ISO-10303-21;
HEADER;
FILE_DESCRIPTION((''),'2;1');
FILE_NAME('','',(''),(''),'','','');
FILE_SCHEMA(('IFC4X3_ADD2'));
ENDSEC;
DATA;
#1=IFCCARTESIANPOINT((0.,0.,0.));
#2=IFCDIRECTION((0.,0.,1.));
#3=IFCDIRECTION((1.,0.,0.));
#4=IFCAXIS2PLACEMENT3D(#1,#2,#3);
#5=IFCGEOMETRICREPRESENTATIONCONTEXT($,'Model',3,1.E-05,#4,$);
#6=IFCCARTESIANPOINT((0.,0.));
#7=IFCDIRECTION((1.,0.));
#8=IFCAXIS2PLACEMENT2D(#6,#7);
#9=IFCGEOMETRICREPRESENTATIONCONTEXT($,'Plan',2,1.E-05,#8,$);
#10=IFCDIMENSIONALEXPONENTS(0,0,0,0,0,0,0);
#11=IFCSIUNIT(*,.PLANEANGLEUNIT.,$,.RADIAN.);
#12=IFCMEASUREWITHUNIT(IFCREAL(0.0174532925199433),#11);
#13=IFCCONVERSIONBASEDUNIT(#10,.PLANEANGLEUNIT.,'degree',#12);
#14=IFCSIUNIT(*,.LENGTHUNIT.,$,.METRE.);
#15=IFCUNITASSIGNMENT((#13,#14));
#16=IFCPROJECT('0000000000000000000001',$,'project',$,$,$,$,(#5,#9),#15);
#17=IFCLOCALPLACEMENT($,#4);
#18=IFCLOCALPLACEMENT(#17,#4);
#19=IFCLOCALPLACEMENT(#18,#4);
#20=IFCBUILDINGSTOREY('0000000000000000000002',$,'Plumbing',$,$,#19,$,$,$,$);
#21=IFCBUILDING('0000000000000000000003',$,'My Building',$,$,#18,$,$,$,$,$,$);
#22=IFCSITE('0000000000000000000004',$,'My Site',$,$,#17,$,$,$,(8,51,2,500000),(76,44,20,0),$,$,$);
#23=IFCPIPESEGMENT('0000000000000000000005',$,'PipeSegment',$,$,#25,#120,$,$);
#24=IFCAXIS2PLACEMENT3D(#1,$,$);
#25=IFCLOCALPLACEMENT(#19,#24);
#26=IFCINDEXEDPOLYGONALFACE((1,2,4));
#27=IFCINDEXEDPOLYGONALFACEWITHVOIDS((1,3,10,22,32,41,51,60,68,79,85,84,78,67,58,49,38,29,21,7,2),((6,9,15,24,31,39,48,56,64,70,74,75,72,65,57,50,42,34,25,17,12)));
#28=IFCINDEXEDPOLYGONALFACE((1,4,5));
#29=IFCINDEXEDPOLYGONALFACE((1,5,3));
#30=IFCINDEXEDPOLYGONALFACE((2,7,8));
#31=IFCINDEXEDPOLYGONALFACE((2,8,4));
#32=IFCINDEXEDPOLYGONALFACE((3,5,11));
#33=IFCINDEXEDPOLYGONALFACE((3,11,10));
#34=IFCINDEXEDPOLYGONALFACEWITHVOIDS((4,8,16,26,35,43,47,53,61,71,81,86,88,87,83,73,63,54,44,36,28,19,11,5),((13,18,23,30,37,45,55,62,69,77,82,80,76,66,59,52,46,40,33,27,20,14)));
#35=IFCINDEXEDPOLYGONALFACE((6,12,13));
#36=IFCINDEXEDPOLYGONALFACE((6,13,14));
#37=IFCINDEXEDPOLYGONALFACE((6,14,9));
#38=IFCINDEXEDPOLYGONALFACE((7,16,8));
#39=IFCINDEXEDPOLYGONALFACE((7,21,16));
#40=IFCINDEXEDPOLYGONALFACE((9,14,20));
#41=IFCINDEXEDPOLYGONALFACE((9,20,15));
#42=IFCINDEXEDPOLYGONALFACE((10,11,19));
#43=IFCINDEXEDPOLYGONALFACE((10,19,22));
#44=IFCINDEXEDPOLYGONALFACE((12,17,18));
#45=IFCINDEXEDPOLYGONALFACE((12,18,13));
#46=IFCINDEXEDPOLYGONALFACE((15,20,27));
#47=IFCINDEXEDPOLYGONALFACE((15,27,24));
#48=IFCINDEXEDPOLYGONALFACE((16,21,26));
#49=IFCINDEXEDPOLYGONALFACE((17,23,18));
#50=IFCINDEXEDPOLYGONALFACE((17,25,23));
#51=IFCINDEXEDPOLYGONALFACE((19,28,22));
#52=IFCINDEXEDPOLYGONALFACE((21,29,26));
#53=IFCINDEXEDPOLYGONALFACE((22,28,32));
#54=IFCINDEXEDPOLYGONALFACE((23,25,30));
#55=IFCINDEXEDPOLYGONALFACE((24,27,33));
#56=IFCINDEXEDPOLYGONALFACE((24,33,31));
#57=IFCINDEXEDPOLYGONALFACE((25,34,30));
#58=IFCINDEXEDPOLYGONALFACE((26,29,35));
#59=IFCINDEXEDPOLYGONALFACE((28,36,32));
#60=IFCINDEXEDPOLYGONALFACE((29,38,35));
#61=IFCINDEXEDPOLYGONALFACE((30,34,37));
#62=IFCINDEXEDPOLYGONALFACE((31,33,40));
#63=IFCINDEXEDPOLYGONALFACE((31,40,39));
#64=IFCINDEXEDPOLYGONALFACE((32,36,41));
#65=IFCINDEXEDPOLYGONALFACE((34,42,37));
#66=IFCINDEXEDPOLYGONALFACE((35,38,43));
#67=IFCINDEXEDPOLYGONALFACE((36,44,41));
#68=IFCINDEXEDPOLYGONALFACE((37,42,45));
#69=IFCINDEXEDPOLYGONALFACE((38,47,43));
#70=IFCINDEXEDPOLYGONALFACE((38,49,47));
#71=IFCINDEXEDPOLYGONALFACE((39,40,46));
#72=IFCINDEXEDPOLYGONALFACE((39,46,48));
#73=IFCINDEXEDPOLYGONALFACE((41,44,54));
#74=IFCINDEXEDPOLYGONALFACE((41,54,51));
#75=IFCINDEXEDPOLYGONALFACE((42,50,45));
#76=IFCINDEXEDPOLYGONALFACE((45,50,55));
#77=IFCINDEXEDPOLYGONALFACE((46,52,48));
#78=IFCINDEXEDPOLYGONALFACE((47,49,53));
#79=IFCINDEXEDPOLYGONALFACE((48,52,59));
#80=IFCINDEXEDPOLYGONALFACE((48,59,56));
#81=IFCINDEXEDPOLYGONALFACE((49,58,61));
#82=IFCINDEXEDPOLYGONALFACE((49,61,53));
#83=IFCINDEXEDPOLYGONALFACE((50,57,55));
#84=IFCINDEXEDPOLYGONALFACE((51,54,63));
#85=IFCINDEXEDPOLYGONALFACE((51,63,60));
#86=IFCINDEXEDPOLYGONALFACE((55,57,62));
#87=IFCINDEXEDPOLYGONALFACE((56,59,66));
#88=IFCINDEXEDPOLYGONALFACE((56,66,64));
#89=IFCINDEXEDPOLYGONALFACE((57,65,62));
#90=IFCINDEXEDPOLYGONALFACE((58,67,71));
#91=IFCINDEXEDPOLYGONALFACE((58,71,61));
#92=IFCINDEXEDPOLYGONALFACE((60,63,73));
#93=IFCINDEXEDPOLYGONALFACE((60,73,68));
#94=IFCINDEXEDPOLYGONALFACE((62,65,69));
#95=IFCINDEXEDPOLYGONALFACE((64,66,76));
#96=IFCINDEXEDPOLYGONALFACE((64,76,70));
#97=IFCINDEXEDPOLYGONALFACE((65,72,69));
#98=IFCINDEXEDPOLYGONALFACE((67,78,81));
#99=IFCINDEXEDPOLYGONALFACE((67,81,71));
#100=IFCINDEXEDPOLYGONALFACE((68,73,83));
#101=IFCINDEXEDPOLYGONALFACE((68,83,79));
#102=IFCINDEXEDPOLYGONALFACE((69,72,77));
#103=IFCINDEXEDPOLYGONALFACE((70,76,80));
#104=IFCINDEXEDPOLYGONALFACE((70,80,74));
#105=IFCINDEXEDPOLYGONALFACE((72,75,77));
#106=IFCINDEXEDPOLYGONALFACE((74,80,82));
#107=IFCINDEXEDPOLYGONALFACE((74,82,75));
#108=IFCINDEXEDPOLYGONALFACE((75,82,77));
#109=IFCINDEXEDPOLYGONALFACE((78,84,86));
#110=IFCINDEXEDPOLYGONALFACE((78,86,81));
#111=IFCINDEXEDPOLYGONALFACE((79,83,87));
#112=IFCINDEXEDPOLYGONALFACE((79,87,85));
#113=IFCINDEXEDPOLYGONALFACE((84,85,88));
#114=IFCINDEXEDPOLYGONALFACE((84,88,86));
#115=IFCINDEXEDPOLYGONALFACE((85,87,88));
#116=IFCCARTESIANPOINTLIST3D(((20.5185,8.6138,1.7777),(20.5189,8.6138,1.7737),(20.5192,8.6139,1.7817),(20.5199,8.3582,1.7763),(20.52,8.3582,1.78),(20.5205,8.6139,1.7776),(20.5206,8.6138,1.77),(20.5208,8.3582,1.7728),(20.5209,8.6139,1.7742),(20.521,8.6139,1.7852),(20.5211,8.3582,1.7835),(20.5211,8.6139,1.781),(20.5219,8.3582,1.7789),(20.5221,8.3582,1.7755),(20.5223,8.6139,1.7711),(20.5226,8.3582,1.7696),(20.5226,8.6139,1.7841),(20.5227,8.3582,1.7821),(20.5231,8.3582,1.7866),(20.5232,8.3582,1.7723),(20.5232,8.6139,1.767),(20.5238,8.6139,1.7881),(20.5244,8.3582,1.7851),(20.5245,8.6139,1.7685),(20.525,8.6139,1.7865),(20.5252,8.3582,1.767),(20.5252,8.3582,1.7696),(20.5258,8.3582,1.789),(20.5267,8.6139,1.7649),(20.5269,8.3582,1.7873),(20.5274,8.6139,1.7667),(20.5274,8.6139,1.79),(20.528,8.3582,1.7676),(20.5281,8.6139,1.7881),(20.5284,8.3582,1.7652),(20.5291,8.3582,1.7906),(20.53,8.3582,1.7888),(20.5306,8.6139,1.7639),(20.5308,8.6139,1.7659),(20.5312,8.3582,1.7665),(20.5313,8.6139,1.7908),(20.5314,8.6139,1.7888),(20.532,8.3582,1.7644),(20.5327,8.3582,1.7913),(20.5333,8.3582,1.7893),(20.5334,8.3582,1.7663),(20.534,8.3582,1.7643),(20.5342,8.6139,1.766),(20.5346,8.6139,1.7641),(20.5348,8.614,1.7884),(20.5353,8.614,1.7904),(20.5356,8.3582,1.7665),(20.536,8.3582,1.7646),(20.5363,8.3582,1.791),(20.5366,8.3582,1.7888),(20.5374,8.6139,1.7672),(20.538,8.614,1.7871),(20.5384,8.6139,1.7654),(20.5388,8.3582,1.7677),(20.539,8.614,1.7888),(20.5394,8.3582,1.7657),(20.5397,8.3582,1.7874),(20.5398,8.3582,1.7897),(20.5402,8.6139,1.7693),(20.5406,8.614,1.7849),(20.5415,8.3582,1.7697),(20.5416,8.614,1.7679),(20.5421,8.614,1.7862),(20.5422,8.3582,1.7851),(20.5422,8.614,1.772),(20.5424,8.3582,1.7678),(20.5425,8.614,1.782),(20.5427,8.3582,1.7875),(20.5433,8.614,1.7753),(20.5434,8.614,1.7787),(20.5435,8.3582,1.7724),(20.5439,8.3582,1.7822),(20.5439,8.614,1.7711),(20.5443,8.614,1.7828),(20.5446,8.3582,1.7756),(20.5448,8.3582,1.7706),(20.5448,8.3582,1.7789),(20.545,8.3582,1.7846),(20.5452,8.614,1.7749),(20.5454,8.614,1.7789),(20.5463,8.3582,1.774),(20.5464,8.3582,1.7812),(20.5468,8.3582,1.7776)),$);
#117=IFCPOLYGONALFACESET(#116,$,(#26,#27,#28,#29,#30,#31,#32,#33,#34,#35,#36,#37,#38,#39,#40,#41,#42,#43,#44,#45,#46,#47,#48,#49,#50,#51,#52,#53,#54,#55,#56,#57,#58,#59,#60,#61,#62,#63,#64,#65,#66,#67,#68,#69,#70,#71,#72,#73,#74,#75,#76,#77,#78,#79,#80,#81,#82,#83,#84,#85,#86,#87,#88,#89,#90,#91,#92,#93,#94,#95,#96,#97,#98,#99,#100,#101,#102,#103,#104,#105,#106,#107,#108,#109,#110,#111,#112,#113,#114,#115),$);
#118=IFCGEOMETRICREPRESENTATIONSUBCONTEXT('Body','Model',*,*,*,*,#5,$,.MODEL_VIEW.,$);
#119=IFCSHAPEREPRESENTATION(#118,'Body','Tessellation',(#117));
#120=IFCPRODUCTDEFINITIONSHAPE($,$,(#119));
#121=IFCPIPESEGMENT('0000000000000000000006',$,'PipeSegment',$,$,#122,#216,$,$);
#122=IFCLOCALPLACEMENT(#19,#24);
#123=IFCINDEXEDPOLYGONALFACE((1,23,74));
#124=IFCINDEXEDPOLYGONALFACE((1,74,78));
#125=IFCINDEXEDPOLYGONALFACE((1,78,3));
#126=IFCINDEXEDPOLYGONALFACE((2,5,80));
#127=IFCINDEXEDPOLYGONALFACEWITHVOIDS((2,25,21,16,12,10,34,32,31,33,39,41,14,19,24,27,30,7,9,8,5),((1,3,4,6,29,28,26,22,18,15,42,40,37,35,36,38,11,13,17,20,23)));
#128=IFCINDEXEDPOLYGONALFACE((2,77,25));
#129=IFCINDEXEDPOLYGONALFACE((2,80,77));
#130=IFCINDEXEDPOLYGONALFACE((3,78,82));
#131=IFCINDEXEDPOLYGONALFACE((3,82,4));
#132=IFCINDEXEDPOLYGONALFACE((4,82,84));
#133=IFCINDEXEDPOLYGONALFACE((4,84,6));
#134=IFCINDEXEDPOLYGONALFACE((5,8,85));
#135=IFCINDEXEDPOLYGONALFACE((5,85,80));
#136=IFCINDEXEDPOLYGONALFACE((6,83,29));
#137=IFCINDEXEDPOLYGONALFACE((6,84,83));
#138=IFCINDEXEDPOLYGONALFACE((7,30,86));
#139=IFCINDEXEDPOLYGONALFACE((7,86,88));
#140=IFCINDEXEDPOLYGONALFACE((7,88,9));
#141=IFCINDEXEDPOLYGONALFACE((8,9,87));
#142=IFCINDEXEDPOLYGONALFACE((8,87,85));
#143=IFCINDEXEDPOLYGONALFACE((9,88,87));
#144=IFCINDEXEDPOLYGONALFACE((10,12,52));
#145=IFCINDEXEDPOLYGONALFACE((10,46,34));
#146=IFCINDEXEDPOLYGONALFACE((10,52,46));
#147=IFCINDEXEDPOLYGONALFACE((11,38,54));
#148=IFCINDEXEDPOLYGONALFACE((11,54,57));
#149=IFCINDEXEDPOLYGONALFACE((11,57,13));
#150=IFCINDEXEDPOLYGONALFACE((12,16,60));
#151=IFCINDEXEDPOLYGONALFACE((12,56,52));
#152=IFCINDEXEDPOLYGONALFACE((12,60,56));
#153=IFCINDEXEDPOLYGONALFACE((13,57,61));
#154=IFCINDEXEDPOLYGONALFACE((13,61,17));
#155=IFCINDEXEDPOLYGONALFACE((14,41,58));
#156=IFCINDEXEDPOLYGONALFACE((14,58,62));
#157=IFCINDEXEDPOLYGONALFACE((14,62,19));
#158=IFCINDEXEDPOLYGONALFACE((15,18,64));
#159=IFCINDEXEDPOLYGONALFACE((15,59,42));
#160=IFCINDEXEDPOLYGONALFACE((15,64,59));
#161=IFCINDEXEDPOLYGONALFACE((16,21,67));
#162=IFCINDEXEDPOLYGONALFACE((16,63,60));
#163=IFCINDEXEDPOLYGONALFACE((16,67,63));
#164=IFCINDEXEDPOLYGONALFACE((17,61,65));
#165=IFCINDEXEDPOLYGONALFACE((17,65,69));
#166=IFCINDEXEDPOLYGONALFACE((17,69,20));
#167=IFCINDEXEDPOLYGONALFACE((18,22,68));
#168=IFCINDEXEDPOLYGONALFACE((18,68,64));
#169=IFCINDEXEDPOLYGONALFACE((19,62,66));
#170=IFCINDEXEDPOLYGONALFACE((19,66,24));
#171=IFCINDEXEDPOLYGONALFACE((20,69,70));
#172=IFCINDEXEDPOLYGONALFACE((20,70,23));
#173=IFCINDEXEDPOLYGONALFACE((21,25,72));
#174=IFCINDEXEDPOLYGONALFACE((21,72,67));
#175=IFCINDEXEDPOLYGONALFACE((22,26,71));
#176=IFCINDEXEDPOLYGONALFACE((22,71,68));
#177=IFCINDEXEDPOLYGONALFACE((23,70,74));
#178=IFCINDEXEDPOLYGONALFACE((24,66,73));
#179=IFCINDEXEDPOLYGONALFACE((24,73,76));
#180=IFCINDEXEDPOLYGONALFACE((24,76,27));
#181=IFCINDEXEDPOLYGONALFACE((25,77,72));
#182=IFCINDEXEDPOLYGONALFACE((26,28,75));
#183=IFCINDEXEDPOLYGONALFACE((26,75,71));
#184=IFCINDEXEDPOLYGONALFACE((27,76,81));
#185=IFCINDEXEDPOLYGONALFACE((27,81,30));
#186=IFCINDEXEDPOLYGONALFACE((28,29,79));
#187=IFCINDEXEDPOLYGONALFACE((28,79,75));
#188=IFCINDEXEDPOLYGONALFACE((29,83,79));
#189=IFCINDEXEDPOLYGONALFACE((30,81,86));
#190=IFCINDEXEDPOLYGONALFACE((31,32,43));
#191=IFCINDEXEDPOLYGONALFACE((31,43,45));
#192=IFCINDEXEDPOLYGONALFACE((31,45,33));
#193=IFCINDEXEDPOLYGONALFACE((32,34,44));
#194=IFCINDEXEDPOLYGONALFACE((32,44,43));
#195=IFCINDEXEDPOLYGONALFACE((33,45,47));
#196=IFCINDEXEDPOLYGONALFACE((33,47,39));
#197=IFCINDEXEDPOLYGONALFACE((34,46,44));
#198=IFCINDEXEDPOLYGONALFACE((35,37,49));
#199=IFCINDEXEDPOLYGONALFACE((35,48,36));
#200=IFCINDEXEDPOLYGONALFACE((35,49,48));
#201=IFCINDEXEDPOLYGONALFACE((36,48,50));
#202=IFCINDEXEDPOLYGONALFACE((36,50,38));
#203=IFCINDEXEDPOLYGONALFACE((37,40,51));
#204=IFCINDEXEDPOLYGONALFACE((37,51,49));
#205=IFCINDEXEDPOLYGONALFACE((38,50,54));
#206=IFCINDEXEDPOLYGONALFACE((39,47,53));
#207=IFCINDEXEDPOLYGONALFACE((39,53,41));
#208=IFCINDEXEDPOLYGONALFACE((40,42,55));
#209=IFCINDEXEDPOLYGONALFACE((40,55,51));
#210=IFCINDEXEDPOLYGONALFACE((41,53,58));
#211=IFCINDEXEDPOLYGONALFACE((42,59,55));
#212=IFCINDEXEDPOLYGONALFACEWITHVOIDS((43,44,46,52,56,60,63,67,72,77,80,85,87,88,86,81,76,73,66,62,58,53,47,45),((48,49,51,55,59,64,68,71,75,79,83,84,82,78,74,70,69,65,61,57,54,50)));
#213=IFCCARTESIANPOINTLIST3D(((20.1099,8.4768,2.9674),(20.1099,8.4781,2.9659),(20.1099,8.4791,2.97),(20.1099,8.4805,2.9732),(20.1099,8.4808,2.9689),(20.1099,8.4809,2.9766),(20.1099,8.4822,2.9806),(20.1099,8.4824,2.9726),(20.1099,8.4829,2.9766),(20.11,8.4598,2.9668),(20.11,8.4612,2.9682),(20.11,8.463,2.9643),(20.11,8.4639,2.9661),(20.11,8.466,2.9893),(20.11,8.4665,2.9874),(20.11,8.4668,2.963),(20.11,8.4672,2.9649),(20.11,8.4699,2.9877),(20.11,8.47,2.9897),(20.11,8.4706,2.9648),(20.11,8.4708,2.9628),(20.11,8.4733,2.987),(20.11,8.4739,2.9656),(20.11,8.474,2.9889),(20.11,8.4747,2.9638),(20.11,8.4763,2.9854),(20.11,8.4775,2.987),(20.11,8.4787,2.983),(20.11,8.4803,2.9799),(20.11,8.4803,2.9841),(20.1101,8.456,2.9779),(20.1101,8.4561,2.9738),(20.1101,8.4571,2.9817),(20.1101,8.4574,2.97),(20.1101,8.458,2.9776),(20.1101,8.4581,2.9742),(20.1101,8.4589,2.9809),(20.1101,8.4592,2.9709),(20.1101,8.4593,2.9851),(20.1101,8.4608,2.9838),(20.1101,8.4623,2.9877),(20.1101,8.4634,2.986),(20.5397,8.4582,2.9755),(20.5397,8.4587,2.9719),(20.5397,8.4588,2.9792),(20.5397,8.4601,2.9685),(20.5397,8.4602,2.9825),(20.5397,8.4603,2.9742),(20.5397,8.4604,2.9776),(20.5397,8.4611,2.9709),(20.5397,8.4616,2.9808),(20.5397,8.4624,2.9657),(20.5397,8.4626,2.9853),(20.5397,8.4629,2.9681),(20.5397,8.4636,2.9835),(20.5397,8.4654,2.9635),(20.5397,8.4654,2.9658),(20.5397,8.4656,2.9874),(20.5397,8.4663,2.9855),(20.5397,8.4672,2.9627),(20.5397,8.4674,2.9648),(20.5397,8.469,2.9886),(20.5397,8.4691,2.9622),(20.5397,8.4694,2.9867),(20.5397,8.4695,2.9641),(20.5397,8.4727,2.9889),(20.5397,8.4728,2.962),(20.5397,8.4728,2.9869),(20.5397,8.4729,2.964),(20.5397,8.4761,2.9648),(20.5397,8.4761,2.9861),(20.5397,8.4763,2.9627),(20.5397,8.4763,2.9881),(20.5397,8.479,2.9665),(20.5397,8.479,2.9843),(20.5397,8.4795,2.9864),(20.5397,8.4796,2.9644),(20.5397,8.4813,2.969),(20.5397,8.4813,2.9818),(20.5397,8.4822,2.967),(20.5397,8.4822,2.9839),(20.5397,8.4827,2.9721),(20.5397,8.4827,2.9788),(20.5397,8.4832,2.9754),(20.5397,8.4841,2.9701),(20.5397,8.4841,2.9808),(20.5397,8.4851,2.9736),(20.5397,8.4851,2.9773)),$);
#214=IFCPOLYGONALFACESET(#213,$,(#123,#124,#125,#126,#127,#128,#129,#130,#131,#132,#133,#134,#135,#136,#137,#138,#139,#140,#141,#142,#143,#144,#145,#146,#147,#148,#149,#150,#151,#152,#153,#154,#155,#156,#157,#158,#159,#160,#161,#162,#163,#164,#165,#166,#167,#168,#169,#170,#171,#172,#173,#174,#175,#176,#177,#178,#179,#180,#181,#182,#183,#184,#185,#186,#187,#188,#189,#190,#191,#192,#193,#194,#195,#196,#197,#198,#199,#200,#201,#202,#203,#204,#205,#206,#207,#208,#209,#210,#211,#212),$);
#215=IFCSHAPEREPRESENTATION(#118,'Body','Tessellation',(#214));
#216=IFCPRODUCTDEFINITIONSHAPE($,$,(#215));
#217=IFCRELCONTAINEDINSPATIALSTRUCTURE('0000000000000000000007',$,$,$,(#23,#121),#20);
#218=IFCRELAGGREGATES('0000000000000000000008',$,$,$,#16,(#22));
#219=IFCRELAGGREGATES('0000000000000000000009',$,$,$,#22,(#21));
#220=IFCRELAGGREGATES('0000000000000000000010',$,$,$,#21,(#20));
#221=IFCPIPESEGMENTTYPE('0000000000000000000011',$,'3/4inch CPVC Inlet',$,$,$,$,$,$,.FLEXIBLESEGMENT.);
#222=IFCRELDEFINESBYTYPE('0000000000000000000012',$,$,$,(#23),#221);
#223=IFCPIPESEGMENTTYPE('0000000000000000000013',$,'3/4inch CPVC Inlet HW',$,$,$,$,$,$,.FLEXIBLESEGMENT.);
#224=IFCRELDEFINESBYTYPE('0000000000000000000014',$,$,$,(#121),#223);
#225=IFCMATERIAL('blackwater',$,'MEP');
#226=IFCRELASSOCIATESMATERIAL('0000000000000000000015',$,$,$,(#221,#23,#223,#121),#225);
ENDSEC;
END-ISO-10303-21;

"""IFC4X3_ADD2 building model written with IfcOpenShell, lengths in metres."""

from ifc_helpers import new_model, entity, si_unit, converted_unit, frame, origin_with_axes, origin_2d_with_axis, place, context, subcontext, project, spatial, hollow_circle, extrude, clip, halfspace, material, material_profile, profile_set, profile_usage, type_object, element, save


model = new_model("IFC4X3_ADD2")

# Units and contexts
model_context = context("Model", 3, precision=1e-05, world=origin_with_axes())
plan_context = context("Plan", 2, precision=1e-05, world=origin_2d_with_axis())
body_context = subcontext(model_context, "Body", "Model", "MODEL_VIEW")
ifc_project = project(units=[converted_unit("PLANEANGLEUNIT", "degree", entity("IfcReal", 0.0174532925199433), si_unit("PLANEANGLEUNIT", "RADIAN"), dimensions=[0, 0, 0, 0, 0, 0, 0]), si_unit("LENGTHUNIT", "METRE")], contexts=[model_context, plan_context])

# Site, building, storey
site_placement = place(None, origin_with_axes())
site = spatial("IfcSite", under=ifc_project, at=site_placement, Name="My Site", RefLatitude=(8, 51, 2, 500000), RefLongitude=(76, 44, 20, 0))
building_placement = place(site_placement, origin_with_axes())
building = spatial("IfcBuilding", under=site, at=building_placement, Name="My Building")
storey_placement = place(building_placement, origin_with_axes())
storey = spatial("IfcBuildingStorey", under=building, at=storey_placement, Name="Plumbing")

# Pipe segments
ifc_material_1 = material(Name="blackwater", Category="MEP")
ifc_material_profile_1 = material_profile(ifc_material_1, hollow_circle(Radius=0.0135, WallThickness=0.002))
ifc_profile_set_1 = profile_set([ifc_material_profile_1], Name="water")
ifc_profile_usage_1 = profile_usage(ifc_profile_set_1)
pipe_segment_type_1 = type_object("IfcPipeSegmentType", Name="3/4inch CPVC Inlet", PredefinedType="FLEXIBLESEGMENT", material=ifc_profile_set_1)
pipe_segment_1_placement = place(storey_placement, frame((20.532, 8.6139, 1.7773), z_axis=(0.005392, -0.999984, 0.001876), x_axis=(0.194654, -0.00079, -0.980872)))
element("IfcPipeSegment", 1, at=pipe_segment_1_placement, inside=storey, type_object=pipe_segment_type_1, material=ifc_profile_usage_1, Name="PipeSegment", context=body_context, shape_type="Clipping", body=[
    clip(extrude(hollow_circle(Radius=0.0135, WallThickness=0.002), origin_with_axes(), (0.0, 0.0, 1.0), 0.2827), halfspace(frame((-0.0129, 0.0228, 0.2559), z_axis=(0.00079, -0.005655, 0.999984), x_axis=(-1.0, 0.0, 0.00079)), False)),
])
ifc_material_profile_2 = material_profile(ifc_material_1, hollow_circle(Radius=0.0135, WallThickness=0.002))
ifc_profile_set_2 = profile_set([ifc_material_profile_2], Name="water")
pipe_segment_type_2 = type_object("IfcPipeSegmentType", Name="3/4inch CPVC Inlet HW", PredefinedType="FLEXIBLESEGMENT", material=ifc_profile_set_2)
ifc_profile_usage_2 = profile_usage(ifc_profile_set_2)
pipe_segment_2_placement = place(storey_placement, frame((20.5667, 8.4719, 2.9754), z_axis=(-0.999984, -0.005393, 0.001876), x_axis=(-0.00079, -0.194654, -0.980872)))
element("IfcPipeSegment", 2, at=pipe_segment_2_placement, inside=storey, type_object=pipe_segment_type_2, material=ifc_profile_usage_2, Name="PipeSegment", context=body_context, shape_type="Clipping", body=[
    clip(extrude(hollow_circle(Radius=0.0135, WallThickness=0.002), origin_with_axes(), (0.0, 0.0, 1.0), 0.4567), halfspace(frame((-0.04, -0.022, 0.0269), z_axis=(-0.00079, 0.005655, -0.999984), x_axis=(1.0, 0.0, -0.00079)), False)),
])

save(model, "model.ifc")
